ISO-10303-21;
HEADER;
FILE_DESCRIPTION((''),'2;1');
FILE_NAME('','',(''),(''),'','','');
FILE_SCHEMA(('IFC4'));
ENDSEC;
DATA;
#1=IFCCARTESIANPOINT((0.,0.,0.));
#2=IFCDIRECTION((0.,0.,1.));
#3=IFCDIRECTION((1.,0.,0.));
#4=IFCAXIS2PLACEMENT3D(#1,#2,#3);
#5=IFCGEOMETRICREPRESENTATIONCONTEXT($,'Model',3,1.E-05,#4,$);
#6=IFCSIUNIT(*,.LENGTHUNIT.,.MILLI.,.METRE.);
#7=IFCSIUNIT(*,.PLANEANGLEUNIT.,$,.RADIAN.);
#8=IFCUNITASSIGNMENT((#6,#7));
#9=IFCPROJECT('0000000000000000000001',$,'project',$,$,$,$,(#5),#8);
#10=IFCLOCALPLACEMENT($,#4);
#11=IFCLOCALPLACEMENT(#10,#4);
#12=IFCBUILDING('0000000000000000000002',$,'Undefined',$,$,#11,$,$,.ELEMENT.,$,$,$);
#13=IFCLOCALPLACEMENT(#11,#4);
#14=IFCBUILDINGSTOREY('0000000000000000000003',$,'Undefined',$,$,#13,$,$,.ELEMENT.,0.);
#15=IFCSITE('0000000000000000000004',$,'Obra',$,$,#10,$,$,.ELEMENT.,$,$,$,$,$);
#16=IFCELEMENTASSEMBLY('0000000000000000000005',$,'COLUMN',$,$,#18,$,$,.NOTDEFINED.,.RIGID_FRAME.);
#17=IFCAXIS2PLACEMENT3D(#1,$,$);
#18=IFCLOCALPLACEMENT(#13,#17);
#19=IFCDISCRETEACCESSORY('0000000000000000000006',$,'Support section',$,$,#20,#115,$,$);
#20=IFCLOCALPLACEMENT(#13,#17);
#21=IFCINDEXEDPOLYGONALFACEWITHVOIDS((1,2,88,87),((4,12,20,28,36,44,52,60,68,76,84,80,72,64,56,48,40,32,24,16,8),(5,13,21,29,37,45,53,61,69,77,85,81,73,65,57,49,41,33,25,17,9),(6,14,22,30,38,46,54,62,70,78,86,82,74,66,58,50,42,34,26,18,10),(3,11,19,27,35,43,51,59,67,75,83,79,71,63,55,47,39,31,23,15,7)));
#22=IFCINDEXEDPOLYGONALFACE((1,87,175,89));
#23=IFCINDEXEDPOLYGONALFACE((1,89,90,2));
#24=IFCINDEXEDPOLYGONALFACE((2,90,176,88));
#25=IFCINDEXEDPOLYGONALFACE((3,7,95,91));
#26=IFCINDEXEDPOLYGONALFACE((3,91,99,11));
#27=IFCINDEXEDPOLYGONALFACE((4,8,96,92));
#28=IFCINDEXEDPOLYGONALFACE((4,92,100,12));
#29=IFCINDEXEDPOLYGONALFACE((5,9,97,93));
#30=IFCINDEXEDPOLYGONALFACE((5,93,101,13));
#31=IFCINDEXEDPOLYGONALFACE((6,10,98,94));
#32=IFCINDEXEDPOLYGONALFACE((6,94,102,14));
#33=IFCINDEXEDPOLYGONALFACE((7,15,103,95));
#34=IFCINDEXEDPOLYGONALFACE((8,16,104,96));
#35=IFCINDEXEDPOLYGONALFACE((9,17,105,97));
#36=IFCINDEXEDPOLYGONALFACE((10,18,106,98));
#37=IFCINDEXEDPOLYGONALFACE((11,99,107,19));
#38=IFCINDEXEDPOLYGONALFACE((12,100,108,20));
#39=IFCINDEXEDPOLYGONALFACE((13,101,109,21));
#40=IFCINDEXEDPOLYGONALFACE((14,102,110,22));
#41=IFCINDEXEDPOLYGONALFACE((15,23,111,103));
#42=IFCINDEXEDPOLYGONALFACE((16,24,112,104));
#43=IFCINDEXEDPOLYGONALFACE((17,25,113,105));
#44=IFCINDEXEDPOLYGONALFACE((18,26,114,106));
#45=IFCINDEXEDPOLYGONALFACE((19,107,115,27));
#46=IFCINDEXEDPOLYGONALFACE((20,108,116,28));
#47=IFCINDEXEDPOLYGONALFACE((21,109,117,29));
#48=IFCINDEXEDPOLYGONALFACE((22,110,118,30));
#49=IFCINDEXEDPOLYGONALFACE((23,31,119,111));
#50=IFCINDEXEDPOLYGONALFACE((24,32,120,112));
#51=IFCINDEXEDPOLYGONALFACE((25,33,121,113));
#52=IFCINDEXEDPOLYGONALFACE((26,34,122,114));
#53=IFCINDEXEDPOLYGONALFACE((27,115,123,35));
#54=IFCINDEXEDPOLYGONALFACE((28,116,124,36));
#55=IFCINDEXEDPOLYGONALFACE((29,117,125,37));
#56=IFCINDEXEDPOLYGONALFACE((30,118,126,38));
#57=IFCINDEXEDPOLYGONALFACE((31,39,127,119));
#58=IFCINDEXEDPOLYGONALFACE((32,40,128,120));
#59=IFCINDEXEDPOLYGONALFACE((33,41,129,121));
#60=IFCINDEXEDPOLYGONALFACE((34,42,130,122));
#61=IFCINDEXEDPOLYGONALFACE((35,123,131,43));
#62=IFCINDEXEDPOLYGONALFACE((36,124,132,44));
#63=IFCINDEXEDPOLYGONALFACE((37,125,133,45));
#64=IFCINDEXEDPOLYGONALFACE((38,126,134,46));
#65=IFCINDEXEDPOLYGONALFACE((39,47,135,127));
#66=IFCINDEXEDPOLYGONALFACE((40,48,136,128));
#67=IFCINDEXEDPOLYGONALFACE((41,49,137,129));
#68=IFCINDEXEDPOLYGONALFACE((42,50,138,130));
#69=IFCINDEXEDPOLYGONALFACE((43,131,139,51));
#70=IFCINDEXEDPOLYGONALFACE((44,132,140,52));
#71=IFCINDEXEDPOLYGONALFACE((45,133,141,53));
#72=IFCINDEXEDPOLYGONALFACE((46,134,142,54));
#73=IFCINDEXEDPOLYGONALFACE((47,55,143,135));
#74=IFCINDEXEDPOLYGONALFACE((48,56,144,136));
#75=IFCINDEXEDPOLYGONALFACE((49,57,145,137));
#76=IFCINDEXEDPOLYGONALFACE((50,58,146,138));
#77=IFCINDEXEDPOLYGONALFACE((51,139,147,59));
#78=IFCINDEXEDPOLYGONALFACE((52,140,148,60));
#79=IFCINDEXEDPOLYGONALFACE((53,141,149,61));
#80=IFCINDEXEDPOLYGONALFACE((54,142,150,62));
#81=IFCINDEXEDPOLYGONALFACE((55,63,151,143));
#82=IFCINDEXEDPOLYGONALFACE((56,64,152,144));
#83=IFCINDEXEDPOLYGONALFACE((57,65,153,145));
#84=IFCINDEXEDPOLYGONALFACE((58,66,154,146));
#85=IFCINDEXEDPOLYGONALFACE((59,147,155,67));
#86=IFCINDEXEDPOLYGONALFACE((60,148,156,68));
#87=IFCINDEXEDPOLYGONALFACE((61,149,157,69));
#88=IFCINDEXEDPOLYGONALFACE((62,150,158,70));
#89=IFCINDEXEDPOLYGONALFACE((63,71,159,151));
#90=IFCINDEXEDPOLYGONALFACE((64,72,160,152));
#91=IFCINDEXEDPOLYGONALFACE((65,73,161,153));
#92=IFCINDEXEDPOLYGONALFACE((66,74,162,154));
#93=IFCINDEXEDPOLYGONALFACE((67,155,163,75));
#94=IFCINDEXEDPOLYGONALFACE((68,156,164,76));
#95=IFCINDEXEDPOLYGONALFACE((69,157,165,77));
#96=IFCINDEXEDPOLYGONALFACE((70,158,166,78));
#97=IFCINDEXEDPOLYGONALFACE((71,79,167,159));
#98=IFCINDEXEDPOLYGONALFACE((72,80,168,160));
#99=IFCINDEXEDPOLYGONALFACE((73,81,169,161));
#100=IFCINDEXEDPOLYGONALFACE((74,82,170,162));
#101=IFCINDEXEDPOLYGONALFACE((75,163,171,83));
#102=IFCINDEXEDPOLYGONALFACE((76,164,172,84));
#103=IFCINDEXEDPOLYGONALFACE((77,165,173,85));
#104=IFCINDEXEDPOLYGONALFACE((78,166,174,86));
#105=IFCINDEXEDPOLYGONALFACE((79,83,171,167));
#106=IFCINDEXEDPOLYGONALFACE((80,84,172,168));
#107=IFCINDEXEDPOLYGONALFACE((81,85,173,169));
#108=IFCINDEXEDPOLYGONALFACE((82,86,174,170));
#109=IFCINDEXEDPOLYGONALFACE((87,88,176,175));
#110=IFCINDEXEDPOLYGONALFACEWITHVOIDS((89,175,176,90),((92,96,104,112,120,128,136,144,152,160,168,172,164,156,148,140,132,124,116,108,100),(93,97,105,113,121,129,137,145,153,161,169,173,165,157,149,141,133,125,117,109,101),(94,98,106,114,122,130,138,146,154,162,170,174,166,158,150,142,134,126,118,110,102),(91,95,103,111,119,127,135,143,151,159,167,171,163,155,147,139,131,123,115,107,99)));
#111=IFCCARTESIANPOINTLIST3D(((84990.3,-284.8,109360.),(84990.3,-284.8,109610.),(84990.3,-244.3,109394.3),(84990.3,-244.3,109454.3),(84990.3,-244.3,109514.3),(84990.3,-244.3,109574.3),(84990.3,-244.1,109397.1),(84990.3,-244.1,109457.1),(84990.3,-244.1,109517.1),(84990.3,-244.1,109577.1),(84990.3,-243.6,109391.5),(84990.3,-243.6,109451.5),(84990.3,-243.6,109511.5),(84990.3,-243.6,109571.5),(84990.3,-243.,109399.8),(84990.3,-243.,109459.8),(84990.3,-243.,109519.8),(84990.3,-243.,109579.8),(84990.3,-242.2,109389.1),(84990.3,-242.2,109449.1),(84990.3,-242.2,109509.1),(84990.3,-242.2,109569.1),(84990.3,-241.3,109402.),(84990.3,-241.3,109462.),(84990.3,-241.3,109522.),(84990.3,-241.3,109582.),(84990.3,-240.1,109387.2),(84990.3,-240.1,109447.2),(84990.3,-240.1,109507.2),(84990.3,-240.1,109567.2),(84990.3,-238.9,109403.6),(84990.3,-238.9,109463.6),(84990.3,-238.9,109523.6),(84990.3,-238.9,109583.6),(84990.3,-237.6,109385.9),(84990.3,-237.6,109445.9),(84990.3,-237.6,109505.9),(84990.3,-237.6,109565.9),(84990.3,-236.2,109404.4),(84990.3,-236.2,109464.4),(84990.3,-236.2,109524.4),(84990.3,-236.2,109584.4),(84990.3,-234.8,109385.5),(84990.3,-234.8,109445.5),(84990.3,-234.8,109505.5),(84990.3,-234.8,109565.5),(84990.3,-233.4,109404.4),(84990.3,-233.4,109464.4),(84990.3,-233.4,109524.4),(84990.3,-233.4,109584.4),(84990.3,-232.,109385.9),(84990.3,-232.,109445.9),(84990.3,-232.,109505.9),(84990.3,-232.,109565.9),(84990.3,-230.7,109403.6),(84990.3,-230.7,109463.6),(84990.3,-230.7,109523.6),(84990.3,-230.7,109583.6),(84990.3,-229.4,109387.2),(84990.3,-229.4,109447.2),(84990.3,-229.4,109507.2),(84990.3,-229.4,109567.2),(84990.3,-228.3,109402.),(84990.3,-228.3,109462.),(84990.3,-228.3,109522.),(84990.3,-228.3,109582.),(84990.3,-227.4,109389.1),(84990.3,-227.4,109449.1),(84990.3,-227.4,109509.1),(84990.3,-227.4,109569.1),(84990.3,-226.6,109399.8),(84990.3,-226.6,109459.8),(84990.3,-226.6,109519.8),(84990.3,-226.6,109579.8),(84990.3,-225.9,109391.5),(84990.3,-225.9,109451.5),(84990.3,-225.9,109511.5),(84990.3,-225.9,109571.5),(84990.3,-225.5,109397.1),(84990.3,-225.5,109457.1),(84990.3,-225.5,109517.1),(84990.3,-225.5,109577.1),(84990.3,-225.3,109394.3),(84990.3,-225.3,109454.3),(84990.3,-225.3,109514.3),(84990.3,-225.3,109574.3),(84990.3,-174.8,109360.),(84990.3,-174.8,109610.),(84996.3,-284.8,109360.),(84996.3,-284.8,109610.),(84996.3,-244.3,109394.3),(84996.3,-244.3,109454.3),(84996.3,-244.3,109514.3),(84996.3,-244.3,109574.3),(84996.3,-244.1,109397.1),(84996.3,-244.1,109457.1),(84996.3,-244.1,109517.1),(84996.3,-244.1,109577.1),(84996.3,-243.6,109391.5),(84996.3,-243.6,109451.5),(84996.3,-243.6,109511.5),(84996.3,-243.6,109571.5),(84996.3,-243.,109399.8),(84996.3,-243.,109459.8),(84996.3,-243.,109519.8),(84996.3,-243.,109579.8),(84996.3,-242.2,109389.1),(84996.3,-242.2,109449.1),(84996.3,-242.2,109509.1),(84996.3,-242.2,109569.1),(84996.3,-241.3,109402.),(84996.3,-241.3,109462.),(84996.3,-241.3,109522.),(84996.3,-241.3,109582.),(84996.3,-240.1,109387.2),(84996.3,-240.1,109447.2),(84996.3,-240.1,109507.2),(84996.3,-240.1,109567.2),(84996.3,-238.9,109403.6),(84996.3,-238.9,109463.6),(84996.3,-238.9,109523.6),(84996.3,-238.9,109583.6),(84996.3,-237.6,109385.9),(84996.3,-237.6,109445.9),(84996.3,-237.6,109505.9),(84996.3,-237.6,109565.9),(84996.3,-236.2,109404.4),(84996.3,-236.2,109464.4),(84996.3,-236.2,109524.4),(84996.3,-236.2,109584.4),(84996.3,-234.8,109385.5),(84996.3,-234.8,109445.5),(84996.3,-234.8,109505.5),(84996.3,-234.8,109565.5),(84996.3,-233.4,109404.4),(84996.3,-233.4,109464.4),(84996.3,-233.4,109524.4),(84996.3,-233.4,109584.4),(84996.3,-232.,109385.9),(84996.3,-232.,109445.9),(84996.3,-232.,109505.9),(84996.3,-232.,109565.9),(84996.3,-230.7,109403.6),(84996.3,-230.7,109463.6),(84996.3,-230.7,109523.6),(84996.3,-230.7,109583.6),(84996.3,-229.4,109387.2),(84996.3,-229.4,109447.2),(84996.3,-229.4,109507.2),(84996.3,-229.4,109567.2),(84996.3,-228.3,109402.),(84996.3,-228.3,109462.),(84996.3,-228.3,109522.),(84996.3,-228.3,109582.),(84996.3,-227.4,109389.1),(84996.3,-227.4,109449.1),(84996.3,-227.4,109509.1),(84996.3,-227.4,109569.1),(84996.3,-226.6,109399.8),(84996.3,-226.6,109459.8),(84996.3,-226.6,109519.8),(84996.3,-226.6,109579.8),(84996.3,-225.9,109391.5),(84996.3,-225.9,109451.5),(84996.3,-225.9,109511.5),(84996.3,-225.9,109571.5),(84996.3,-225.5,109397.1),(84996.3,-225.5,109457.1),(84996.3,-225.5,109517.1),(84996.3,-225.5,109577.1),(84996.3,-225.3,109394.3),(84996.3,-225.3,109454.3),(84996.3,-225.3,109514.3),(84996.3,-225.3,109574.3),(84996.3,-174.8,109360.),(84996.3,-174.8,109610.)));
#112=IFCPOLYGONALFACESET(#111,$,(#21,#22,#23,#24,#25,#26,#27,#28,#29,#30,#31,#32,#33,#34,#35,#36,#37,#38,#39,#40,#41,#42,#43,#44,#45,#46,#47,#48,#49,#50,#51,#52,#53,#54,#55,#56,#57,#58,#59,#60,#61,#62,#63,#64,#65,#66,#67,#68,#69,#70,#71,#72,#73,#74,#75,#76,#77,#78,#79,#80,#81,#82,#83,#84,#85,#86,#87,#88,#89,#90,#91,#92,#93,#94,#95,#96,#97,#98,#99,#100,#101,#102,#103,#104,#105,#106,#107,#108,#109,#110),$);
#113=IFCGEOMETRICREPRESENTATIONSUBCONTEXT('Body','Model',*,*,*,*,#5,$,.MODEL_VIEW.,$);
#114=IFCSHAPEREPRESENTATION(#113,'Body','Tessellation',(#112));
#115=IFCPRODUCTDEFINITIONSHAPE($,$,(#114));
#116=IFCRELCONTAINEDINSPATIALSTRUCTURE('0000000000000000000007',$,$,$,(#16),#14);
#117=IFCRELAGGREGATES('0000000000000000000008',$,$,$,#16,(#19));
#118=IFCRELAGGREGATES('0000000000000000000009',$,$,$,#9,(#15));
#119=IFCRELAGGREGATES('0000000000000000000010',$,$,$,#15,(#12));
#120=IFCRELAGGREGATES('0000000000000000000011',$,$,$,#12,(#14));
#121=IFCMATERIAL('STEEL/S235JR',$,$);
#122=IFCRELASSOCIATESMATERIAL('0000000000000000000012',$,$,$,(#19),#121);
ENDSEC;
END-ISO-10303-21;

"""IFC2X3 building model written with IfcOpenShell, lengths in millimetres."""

from ifc_helpers import new_model, si_unit, frame, origin_with_axes, origin_2d_with_axis, place, context, subcontext, project, spatial, rectangle, circle, extrude, source, transform, mapped, material, element, aggregate, save


model = new_model("IFC2X3")

# Units and contexts
model_context = context("Model", 3, precision=1e-05, world=origin_with_axes())
body_context = subcontext(model_context, "Body", "Model", "MODEL_VIEW")
ifc_project = project(units=[si_unit("LENGTHUNIT", "METRE", prefix="MILLI"), si_unit("PLANEANGLEUNIT", "RADIAN")], contexts=[model_context])

# Site, building, storey
site_placement = place(None, origin_with_axes())
site = spatial("IfcSite", under=ifc_project, at=site_placement, Name="Obra", CompositionType="ELEMENT")
building_placement = place(site_placement, origin_with_axes())
building = spatial("IfcBuilding", under=site, at=building_placement, Name="Undefined", CompositionType="ELEMENT")
storey_placement = place(building_placement, origin_with_axes())
storey = spatial("IfcBuildingStorey", under=building, at=storey_placement, Name="Undefined", CompositionType="ELEMENT", Elevation=0.0)

# Element assembly
assembly_1_placement = place(storey_placement, origin_with_axes())
assembly_1 = element("IfcElementAssembly", 1, at=assembly_1_placement, inside=storey, Name="COLUMN", AssemblyPlace="NOTDEFINED", PredefinedType="RIGID_FRAME")
ifc_material_1 = material(Name="STEEL/S235JR")

# Discrete accessory, opening
shared_shape_1 = source(origin_with_axes(), body_context, "Body", "SweptSolid", [
    extrude(circle(Radius=9.5, at=origin_2d_with_axis()), frame((0.0, -9.8, 0.0), z_axis=(0.0, 1.0, 0.0), x_axis=(1.0, 0.0, 0.0)), (0.0, 0.0, 1.0), 6.2),
])
discrete_accessory_1_placement = place(assembly_1_placement, frame((84993.3, -229.8, 109360.0), z_axis=(0.0, 0.0, 1.0), x_axis=(0.0, 1.0, 0.0)))
discrete_accessory_1 = element("IfcDiscreteAccessory", 2, at=discrete_accessory_1_placement, material=ifc_material_1, Name="Support section", context=body_context, shape_type="SweptSolid", body=[
    extrude(rectangle(XDim=6.0, YDim=110.0, at=origin_2d_with_axis()), frame((0.0, 0.0, 250.0), z_axis=(0.0, 0.0, -1.0), x_axis=(0.0, 1.0, 0.0)), (0.0, 0.0, 1.0), 250.0),
])
opening_1_placement = place(assembly_1_placement, frame((85000.0, -184.8, 109650.0), z_axis=(0.0, -1.0, 0.0), x_axis=(0.0, 0.0, -1.0)))
element("IfcOpeningElement", 3, at=opening_1_placement, cuts=discrete_accessory_1, ObjectType="Opening", context=body_context, shape_type="MappedRepresentation", body=[
    mapped(shared_shape_1, transform((75.0, 0.0, 50.0))),
    mapped(shared_shape_1, transform((135.0, 0.0, 50.0))),
    mapped(shared_shape_1, transform((195.0, 0.0, 50.0))),
    mapped(shared_shape_1, transform((255.0, 0.0, 50.0))),
])
aggregate(assembly_1, [discrete_accessory_1])

save(model, "model.ifc")
